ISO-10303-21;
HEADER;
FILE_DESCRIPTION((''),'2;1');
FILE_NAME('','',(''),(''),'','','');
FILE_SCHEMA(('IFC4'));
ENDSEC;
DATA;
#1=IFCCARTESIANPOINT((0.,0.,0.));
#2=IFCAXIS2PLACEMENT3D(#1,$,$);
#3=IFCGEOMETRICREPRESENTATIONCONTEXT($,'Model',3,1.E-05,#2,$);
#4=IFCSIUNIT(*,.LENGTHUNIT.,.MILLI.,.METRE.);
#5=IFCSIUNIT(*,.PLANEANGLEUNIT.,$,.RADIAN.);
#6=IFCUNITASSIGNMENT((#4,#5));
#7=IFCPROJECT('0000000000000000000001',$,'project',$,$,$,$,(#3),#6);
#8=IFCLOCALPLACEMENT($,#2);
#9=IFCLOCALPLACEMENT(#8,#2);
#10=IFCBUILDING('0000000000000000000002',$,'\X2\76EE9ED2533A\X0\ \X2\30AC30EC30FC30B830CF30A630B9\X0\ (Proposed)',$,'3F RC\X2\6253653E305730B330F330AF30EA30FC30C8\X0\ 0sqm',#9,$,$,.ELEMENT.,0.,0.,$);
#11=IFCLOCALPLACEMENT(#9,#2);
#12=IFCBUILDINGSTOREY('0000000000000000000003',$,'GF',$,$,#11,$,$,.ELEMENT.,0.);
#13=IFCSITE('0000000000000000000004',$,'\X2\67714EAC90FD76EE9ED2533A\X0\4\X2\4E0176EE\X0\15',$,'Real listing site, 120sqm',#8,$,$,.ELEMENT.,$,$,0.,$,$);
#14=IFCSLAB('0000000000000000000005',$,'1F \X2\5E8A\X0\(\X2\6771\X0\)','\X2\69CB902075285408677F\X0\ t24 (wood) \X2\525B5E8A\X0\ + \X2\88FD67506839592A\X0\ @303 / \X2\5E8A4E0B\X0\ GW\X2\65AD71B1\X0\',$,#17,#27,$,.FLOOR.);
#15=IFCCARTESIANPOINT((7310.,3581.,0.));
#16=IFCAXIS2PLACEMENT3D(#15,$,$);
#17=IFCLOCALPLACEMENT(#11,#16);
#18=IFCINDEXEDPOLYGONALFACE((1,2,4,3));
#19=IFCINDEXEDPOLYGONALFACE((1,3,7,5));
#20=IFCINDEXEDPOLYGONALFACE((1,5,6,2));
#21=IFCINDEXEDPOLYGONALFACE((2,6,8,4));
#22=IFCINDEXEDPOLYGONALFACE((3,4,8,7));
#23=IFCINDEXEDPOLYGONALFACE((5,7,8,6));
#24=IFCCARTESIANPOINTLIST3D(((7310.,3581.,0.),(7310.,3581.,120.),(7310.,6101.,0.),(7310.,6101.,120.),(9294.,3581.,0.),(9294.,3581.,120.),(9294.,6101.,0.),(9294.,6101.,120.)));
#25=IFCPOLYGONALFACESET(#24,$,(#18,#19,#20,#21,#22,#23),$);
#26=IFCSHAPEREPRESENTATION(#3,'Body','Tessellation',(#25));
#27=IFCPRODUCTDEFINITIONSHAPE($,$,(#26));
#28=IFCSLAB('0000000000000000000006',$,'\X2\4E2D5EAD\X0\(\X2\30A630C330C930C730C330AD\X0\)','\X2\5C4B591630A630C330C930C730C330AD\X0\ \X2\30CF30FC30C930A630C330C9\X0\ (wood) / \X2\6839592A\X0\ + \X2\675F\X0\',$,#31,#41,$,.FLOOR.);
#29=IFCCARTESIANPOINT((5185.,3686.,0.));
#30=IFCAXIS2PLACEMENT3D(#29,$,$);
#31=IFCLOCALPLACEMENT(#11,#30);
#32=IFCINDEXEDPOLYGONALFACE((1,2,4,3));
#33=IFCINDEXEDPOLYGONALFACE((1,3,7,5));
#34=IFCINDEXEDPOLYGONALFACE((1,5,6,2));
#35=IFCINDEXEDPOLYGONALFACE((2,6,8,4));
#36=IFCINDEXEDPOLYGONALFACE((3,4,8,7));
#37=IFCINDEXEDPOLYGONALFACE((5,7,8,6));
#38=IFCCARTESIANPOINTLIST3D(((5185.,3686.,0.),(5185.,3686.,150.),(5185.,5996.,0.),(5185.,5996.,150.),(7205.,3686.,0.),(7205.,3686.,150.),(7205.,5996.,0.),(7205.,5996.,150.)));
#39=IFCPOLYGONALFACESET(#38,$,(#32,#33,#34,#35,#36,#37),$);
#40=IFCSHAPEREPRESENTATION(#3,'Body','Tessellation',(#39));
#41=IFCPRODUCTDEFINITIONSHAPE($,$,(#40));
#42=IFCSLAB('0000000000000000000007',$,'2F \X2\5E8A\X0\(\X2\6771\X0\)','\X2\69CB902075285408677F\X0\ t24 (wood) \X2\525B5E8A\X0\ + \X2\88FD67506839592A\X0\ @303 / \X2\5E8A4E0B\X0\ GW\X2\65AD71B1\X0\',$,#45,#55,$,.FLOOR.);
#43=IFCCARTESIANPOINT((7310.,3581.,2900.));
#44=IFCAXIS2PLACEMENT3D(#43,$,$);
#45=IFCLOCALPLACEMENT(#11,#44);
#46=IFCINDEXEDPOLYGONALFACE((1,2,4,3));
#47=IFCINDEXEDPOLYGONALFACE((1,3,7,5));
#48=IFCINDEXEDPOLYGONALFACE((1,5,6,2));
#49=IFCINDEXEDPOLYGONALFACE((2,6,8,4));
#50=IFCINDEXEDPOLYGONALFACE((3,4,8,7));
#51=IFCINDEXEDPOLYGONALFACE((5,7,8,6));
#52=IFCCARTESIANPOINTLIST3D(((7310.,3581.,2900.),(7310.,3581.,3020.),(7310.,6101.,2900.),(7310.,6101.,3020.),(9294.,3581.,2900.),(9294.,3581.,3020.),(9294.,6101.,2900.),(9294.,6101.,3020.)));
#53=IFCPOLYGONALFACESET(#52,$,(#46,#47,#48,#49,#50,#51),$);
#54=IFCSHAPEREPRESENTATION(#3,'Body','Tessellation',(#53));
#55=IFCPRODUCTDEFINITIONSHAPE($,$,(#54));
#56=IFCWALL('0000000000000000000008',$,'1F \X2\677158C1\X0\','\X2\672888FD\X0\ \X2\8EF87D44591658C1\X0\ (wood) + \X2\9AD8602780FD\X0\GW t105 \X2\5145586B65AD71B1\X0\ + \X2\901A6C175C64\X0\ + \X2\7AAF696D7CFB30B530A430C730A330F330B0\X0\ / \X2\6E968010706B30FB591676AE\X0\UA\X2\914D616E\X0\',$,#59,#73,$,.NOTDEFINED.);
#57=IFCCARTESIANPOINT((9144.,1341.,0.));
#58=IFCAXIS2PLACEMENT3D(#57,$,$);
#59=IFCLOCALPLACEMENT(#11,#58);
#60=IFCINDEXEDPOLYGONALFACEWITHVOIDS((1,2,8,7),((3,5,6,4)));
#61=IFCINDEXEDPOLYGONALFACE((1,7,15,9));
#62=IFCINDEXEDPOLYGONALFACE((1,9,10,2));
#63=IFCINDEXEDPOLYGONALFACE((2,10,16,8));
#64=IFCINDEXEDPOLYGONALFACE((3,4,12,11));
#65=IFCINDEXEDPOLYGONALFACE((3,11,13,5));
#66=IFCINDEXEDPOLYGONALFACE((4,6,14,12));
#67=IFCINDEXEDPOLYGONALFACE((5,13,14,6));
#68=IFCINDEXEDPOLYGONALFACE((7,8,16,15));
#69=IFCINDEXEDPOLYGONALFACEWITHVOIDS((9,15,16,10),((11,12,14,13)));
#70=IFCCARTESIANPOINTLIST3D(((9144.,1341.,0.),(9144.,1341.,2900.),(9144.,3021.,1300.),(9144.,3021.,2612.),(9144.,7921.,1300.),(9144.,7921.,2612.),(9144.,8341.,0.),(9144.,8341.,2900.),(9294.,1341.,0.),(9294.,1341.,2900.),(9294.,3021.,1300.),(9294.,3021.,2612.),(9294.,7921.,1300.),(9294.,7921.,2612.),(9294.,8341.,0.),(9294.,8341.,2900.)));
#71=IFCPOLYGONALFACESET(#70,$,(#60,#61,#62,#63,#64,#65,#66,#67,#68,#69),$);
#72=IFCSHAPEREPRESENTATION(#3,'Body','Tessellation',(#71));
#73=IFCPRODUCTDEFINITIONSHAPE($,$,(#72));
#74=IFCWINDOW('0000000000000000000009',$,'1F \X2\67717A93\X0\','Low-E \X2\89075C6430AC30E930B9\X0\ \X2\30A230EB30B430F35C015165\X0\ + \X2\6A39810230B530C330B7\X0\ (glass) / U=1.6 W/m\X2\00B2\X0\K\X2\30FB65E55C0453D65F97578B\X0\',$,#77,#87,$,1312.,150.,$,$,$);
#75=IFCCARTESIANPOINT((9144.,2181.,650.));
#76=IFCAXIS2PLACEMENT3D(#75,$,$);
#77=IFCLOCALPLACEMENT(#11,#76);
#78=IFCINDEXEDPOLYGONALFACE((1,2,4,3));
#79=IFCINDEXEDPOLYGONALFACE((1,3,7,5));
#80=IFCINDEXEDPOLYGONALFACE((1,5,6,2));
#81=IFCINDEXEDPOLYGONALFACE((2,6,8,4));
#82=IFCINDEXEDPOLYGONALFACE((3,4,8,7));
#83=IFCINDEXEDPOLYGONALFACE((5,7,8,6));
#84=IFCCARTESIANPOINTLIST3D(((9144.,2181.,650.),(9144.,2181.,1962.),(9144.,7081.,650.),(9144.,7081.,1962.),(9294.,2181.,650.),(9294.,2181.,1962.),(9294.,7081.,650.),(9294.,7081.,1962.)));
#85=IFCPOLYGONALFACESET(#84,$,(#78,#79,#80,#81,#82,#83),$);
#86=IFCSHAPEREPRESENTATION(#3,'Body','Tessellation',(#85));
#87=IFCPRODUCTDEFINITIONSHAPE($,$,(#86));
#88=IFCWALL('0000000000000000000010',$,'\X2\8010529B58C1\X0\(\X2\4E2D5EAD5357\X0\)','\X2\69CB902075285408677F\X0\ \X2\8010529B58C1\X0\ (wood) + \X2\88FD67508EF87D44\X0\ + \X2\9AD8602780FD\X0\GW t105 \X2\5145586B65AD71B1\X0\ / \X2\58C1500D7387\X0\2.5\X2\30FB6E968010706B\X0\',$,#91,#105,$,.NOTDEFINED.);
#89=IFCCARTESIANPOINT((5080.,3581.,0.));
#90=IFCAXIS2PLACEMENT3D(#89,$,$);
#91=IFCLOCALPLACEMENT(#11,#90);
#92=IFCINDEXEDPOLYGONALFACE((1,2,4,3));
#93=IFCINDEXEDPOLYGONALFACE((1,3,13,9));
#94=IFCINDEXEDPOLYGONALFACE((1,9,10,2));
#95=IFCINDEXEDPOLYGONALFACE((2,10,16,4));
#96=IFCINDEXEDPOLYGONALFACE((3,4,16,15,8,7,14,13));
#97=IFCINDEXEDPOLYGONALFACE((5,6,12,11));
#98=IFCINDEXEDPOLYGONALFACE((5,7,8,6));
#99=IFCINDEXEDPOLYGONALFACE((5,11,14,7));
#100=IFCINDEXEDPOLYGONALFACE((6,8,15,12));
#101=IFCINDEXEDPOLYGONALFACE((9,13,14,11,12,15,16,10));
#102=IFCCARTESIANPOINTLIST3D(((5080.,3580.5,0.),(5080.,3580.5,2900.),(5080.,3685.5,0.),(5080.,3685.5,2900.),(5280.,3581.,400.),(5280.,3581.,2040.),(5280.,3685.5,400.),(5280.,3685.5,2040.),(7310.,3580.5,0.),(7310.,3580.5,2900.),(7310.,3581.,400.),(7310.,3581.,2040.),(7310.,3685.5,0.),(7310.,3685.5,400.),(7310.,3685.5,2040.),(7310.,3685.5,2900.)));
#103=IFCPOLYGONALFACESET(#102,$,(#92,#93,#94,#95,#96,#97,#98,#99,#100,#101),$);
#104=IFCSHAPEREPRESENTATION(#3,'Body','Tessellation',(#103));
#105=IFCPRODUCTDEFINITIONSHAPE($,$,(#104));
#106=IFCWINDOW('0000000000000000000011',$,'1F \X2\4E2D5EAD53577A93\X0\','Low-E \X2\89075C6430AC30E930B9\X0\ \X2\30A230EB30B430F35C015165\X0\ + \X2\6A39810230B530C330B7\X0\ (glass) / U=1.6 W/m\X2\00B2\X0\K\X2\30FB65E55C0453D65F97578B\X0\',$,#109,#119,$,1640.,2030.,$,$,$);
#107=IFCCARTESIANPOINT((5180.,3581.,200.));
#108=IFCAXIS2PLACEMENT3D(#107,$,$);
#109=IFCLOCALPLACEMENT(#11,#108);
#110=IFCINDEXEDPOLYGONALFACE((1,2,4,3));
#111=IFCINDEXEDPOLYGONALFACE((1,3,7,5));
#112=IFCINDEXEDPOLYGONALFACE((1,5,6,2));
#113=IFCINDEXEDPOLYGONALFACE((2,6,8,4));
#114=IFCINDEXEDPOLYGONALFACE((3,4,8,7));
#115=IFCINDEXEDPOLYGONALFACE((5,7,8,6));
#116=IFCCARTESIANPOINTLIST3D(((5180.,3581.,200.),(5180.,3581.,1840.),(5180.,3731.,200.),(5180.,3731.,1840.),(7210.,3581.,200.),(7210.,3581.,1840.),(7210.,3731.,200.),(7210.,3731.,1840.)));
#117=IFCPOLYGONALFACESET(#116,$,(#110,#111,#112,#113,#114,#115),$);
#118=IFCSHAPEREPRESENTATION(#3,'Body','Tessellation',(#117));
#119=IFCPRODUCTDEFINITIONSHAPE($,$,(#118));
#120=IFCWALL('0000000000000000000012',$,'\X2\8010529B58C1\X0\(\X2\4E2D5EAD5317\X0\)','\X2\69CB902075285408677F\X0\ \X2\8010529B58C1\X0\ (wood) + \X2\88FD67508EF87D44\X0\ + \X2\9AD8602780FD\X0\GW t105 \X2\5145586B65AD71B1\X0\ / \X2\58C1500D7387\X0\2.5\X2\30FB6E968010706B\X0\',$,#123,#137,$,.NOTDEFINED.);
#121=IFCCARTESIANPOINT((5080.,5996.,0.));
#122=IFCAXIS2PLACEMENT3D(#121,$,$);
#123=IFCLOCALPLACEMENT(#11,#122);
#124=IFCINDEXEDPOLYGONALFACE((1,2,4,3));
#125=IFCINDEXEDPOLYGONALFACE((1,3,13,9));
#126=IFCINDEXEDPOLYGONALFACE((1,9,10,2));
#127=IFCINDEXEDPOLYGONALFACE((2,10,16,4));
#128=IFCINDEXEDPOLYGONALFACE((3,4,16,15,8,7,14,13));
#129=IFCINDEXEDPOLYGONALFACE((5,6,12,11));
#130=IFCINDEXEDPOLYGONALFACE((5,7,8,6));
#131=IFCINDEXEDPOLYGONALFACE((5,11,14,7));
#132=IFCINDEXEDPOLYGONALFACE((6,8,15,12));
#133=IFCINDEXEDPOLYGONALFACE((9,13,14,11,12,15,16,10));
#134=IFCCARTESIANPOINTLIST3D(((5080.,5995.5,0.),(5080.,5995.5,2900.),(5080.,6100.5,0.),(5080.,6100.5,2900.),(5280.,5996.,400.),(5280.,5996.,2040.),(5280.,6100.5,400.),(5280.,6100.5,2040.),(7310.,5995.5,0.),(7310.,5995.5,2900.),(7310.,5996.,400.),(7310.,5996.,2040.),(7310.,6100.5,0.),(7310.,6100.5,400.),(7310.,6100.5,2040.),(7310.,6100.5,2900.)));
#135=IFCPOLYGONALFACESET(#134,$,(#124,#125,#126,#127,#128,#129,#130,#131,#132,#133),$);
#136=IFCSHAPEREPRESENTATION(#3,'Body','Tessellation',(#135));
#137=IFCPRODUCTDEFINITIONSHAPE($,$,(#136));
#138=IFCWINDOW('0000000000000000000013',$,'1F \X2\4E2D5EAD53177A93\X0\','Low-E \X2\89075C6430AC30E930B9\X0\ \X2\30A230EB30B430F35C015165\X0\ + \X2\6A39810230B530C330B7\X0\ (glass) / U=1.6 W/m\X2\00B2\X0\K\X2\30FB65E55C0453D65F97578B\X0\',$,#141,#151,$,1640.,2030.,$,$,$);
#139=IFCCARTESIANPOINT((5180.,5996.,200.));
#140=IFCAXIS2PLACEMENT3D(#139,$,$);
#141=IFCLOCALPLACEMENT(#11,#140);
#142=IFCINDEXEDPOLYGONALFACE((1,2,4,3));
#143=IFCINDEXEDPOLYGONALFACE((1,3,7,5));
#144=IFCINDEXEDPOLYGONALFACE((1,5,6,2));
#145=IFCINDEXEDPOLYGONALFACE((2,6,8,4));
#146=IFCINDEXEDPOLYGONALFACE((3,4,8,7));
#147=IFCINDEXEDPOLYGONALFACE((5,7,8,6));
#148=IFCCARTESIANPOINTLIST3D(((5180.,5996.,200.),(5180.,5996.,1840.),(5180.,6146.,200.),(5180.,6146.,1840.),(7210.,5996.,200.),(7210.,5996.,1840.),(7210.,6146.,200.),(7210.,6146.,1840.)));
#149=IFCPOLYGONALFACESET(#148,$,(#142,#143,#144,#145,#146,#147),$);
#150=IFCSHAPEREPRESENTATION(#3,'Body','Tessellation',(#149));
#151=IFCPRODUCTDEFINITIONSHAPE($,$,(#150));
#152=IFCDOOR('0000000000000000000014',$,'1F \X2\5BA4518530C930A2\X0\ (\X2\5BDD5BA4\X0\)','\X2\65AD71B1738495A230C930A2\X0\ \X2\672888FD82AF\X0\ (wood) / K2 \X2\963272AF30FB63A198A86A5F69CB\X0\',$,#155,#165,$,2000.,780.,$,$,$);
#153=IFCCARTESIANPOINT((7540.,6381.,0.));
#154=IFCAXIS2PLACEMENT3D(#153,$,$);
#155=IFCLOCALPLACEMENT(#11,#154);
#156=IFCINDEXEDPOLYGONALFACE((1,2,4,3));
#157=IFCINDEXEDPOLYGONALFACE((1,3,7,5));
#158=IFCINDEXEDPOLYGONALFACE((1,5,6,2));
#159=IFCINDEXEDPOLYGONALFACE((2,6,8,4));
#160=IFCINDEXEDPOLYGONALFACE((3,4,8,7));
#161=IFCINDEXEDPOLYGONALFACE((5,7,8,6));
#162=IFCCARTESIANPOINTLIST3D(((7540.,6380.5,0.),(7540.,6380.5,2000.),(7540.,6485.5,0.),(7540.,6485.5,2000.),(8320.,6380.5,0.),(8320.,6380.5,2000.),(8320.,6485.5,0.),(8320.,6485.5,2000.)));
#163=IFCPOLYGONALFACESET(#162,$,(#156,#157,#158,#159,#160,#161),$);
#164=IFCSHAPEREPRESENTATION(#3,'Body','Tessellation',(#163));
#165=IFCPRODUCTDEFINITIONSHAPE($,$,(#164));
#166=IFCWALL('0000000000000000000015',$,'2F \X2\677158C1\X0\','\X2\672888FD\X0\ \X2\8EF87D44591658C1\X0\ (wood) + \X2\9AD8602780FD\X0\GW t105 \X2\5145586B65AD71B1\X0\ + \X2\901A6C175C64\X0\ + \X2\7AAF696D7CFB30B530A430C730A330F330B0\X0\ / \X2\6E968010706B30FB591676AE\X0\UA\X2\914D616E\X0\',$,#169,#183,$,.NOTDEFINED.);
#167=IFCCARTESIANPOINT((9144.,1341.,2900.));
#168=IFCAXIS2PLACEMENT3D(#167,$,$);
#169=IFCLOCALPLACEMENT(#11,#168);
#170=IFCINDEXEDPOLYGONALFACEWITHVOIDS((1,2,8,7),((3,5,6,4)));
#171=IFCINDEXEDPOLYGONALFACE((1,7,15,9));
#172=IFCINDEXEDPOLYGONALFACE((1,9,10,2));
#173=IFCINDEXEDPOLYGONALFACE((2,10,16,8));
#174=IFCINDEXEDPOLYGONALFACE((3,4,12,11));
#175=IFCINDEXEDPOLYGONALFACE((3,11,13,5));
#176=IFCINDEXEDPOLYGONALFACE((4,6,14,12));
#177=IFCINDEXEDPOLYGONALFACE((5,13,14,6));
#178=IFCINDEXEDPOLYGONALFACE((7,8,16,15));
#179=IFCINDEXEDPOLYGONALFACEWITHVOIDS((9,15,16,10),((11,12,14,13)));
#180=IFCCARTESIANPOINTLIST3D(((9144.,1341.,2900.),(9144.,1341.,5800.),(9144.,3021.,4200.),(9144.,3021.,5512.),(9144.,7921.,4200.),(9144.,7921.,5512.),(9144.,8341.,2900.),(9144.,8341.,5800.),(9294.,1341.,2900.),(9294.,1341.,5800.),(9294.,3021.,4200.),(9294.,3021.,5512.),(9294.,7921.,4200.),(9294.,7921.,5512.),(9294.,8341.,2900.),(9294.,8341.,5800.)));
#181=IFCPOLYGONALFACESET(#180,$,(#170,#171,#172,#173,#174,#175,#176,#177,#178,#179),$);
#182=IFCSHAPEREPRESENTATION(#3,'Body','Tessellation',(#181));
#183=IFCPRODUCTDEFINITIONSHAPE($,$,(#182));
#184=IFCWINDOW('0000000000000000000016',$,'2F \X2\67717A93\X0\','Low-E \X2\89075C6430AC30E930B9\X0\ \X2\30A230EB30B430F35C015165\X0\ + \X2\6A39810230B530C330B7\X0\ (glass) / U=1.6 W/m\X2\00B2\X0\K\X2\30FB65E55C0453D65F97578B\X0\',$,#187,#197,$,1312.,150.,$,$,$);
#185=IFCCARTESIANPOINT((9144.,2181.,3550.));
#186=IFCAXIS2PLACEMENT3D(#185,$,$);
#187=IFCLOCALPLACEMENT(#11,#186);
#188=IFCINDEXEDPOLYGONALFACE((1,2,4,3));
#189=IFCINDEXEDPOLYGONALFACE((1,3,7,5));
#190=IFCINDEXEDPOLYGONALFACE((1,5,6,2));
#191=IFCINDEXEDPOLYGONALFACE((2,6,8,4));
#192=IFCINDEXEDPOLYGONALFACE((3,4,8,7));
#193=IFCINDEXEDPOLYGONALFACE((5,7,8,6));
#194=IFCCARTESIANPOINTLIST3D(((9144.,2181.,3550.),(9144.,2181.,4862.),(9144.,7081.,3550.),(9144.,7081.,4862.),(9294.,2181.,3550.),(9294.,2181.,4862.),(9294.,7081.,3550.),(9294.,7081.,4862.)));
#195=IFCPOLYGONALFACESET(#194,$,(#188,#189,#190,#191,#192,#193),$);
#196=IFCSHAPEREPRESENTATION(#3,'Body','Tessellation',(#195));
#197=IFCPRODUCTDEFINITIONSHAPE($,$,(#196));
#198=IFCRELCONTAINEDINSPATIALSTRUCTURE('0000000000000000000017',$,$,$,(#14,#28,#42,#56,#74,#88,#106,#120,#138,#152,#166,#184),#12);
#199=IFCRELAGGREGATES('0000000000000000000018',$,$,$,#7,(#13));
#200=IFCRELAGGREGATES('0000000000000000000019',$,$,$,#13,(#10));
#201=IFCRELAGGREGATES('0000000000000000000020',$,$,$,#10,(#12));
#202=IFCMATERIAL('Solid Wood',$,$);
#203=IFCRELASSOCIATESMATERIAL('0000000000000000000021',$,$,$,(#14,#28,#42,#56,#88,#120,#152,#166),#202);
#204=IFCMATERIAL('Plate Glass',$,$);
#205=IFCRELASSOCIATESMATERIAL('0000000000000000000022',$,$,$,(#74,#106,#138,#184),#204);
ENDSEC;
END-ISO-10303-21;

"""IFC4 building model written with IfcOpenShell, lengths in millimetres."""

from ifc_helpers import new_model, si_unit, frame, frame_2d, origin, place, context, project, spatial, rectangle, extrude, material, element, fill, save


model = new_model("IFC4")

# Units and contexts
model_context = context("Model", 3, precision=1e-05, world=origin())
ifc_project = project(units=[si_unit("LENGTHUNIT", "METRE", prefix="MILLI"), si_unit("PLANEANGLEUNIT", "RADIAN")], contexts=[model_context])

# Site, building, storey
site_placement = place(None, origin())
site = spatial("IfcSite", under=ifc_project, at=site_placement, Name="東京都目黒区4丁目15", ObjectType="Real listing site, 120sqm", CompositionType="ELEMENT", RefElevation=0.0)
building_placement = place(site_placement, origin())
building = spatial("IfcBuilding", under=site, at=building_placement, Name="目黒区 ガレージハウス (Proposed)", ObjectType="3F RC打放しコンクリート 0sqm", CompositionType="ELEMENT", ElevationOfRefHeight=0.0, ElevationOfTerrain=0.0)
storey_placement = place(building_placement, origin())
storey = spatial("IfcBuildingStorey", under=building, at=storey_placement, Name="GF", CompositionType="ELEMENT", Elevation=0.0)

# Slabs
ifc_material_1 = material(Name="Solid Wood")
slab_1_placement = place(storey_placement, frame((7310.0, 3581.0, 0.0)))
element("IfcSlab", 1, at=slab_1_placement, inside=storey, material=ifc_material_1, Name="1F 床(東)", Description="構造用合板 t24 (wood) 剛床 + 製材根太 @303 / 床下 GW断熱", PredefinedType="FLOOR", context=model_context, shape_type="SweptSolid", body=[
    extrude(rectangle(XDim=1984.0, YDim=2520.0, at=frame_2d((992.0, 1260.0))), frame((7310.0, 3581.0, 0.0)), (0.0, 0.0, 1.0), 120.0),
])
slab_2_placement = place(storey_placement, frame((5185.0, 3686.0, 0.0)))
element("IfcSlab", 2, at=slab_2_placement, inside=storey, material=ifc_material_1, Name="中庭(ウッドデッキ)", Description="屋外ウッドデッキ ハードウッド (wood) / 根太 + 束", PredefinedType="FLOOR", context=model_context, shape_type="SweptSolid", body=[
    extrude(rectangle(XDim=2020.0, YDim=2310.0, at=frame_2d((1010.0, 1155.0))), frame((5185.0, 3686.0, 0.0)), (0.0, 0.0, 1.0), 150.0),
])
slab_3_placement = place(storey_placement, frame((7310.0, 3581.0, 2900.0)))
element("IfcSlab", 3, at=slab_3_placement, inside=storey, material=ifc_material_1, Name="2F 床(東)", Description="構造用合板 t24 (wood) 剛床 + 製材根太 @303 / 床下 GW断熱", PredefinedType="FLOOR", context=model_context, shape_type="SweptSolid", body=[
    extrude(rectangle(XDim=1984.0, YDim=2520.0, at=frame_2d((992.0, 1260.0))), frame((7310.0, 3581.0, 2900.0)), (0.0, 0.0, 1.0), 120.0),
])

# Walls, openings, windows
wall_1_placement = place(storey_placement, frame((9144.0, 1341.0, 0.0)))
wall_1 = element("IfcWall", 4, at=wall_1_placement, inside=storey, material=ifc_material_1, Name="1F 東壁", Description="木製 軸組外壁 (wood) + 高性能GW t105 充填断熱 + 通気層 + 窯業系サイディング / 準耐火・外皮UA配慮", PredefinedType="NOTDEFINED", context=model_context, shape_type="SweptSolid", body=[
    extrude(rectangle(XDim=150.0, YDim=7000.0, at=frame_2d((75.0, 3500.0))), frame((9144.0, 1341.0, 0.0)), (0.0, 0.0, 1.0), 2900.0),
])
opening_1_placement = place(storey_placement, frame((9144.0, 2181.0, 650.0)))
opening_1 = element("IfcOpeningElement", 5, at=opening_1_placement, cuts=wall_1, PredefinedType="NOTDEFINED", context=model_context, shape_type="SweptSolid", body=[
    extrude(rectangle(XDim=150.0, YDim=4900.0, at=frame_2d((75.0, 2450.0))), frame((9144.0, 2181.0, 650.0)), (0.0, 0.0, 1.0), 1312.0),
])
ifc_material_2 = material(Name="Plate Glass")
window_1_placement = place(storey_placement, frame((9144.0, 2181.0, 650.0)))
window_1 = element("IfcWindow", 6, at=window_1_placement, inside=storey, material=ifc_material_2, Name="1F 東窓", Description="Low-E 複層ガラス アルゴン封入 + 樹脂サッシ (glass) / U=1.6 W/m²K・日射取得型", OverallHeight=1312.0, OverallWidth=150.0, context=model_context, shape_type="SweptSolid", body=[
    extrude(rectangle(XDim=150.0, YDim=4900.0, at=frame_2d((75.0, 2450.0))), frame((9144.0, 2181.0, 650.0)), (0.0, 0.0, 1.0), 1312.0),
])
fill(opening_1, window_1)
wall_2_placement = place(storey_placement, frame((5080.0, 3581.0, 0.0)))
wall_2 = element("IfcWall", 7, at=wall_2_placement, inside=storey, material=ifc_material_1, Name="耐力壁(中庭南)", Description="構造用合板 耐力壁 (wood) + 製材軸組 + 高性能GW t105 充填断熱 / 壁倍率2.5・準耐火", PredefinedType="NOTDEFINED", context=model_context, shape_type="SweptSolid", body=[
    extrude(rectangle(XDim=2230.0, YDim=105.0, at=frame_2d((1115.0, 52.0))), frame((5080.0, 3581.0, 0.0)), (0.0, 0.0, 1.0), 2900.0),
])
opening_2_placement = place(storey_placement, frame((5180.0, 3581.0, 200.0)))
opening_2 = element("IfcOpeningElement", 8, at=opening_2_placement, cuts=wall_2, PredefinedType="NOTDEFINED", context=model_context, shape_type="SweptSolid", body=[
    extrude(rectangle(XDim=2030.0, YDim=150.0, at=frame_2d((1015.0, 75.0))), frame((5180.0, 3581.0, 200.0)), (0.0, 0.0, 1.0), 1640.0),
])
window_2_placement = place(storey_placement, frame((5180.0, 3581.0, 200.0)))
window_2 = element("IfcWindow", 9, at=window_2_placement, inside=storey, material=ifc_material_2, Name="1F 中庭南窓", Description="Low-E 複層ガラス アルゴン封入 + 樹脂サッシ (glass) / U=1.6 W/m²K・日射取得型", OverallHeight=1640.0, OverallWidth=2030.0, context=model_context, shape_type="SweptSolid", body=[
    extrude(rectangle(XDim=2030.0, YDim=150.0, at=frame_2d((1015.0, 75.0))), frame((5180.0, 3581.0, 200.0)), (0.0, 0.0, 1.0), 1640.0),
])
fill(opening_2, window_2)
wall_3_placement = place(storey_placement, frame((5080.0, 5996.0, 0.0)))
wall_3 = element("IfcWall", 10, at=wall_3_placement, inside=storey, material=ifc_material_1, Name="耐力壁(中庭北)", Description="構造用合板 耐力壁 (wood) + 製材軸組 + 高性能GW t105 充填断熱 / 壁倍率2.5・準耐火", PredefinedType="NOTDEFINED", context=model_context, shape_type="SweptSolid", body=[
    extrude(rectangle(XDim=2230.0, YDim=105.0, at=frame_2d((1115.0, 52.0))), frame((5080.0, 5996.0, 0.0)), (0.0, 0.0, 1.0), 2900.0),
])
opening_3_placement = place(storey_placement, frame((5180.0, 5996.0, 200.0)))
opening_3 = element("IfcOpeningElement", 11, at=opening_3_placement, cuts=wall_3, PredefinedType="NOTDEFINED", context=model_context, shape_type="SweptSolid", body=[
    extrude(rectangle(XDim=2030.0, YDim=150.0, at=frame_2d((1015.0, 75.0))), frame((5180.0, 5996.0, 200.0)), (0.0, 0.0, 1.0), 1640.0),
])
window_3_placement = place(storey_placement, frame((5180.0, 5996.0, 200.0)))
window_3 = element("IfcWindow", 12, at=window_3_placement, inside=storey, material=ifc_material_2, Name="1F 中庭北窓", Description="Low-E 複層ガラス アルゴン封入 + 樹脂サッシ (glass) / U=1.6 W/m²K・日射取得型", OverallHeight=1640.0, OverallWidth=2030.0, context=model_context, shape_type="SweptSolid", body=[
    extrude(rectangle(XDim=2030.0, YDim=150.0, at=frame_2d((1015.0, 75.0))), frame((5180.0, 5996.0, 200.0)), (0.0, 0.0, 1.0), 1640.0),
])
fill(opening_3, window_3)

# Door
door_placement = place(storey_placement, frame((7540.0, 6381.0, 0.0)))
element("IfcDoor", 13, at=door_placement, inside=storey, material=ifc_material_1, Name="1F 室内ドア (寝室)", Description="断熱玄関ドア 木製芯 (wood) / K2 防犯・採風機構", OverallHeight=2000.0, OverallWidth=780.0, context=model_context, shape_type="SweptSolid", body=[
    extrude(rectangle(XDim=780.0, YDim=105.0, at=frame_2d((390.0, 52.0))), frame((7540.0, 6381.0, 0.0)), (0.0, 0.0, 1.0), 2000.0),
])

# Wall, opening, window
wall_4_placement = place(storey_placement, frame((9144.0, 1341.0, 2900.0)))
wall_4 = element("IfcWall", 14, at=wall_4_placement, inside=storey, material=ifc_material_1, Name="2F 東壁", Description="木製 軸組外壁 (wood) + 高性能GW t105 充填断熱 + 通気層 + 窯業系サイディング / 準耐火・外皮UA配慮", PredefinedType="NOTDEFINED", context=model_context, shape_type="SweptSolid", body=[
    extrude(rectangle(XDim=150.0, YDim=7000.0, at=frame_2d((75.0, 3500.0))), frame((9144.0, 1341.0, 2900.0)), (0.0, 0.0, 1.0), 2900.0),
])
opening_4_placement = place(storey_placement, frame((9144.0, 2181.0, 3550.0)))
opening_4 = element("IfcOpeningElement", 15, at=opening_4_placement, cuts=wall_4, PredefinedType="NOTDEFINED", context=model_context, shape_type="SweptSolid", body=[
    extrude(rectangle(XDim=150.0, YDim=4900.0, at=frame_2d((75.0, 2450.0))), frame((9144.0, 2181.0, 3550.0)), (0.0, 0.0, 1.0), 1312.0),
])
window_4_placement = place(storey_placement, frame((9144.0, 2181.0, 3550.0)))
window_4 = element("IfcWindow", 16, at=window_4_placement, inside=storey, material=ifc_material_2, Name="2F 東窓", Description="Low-E 複層ガラス アルゴン封入 + 樹脂サッシ (glass) / U=1.6 W/m²K・日射取得型", OverallHeight=1312.0, OverallWidth=150.0, context=model_context, shape_type="SweptSolid", body=[
    extrude(rectangle(XDim=150.0, YDim=4900.0, at=frame_2d((75.0, 2450.0))), frame((9144.0, 2181.0, 3550.0)), (0.0, 0.0, 1.0), 1312.0),
])
fill(opening_4, window_4)

save(model, "model.ifc")
